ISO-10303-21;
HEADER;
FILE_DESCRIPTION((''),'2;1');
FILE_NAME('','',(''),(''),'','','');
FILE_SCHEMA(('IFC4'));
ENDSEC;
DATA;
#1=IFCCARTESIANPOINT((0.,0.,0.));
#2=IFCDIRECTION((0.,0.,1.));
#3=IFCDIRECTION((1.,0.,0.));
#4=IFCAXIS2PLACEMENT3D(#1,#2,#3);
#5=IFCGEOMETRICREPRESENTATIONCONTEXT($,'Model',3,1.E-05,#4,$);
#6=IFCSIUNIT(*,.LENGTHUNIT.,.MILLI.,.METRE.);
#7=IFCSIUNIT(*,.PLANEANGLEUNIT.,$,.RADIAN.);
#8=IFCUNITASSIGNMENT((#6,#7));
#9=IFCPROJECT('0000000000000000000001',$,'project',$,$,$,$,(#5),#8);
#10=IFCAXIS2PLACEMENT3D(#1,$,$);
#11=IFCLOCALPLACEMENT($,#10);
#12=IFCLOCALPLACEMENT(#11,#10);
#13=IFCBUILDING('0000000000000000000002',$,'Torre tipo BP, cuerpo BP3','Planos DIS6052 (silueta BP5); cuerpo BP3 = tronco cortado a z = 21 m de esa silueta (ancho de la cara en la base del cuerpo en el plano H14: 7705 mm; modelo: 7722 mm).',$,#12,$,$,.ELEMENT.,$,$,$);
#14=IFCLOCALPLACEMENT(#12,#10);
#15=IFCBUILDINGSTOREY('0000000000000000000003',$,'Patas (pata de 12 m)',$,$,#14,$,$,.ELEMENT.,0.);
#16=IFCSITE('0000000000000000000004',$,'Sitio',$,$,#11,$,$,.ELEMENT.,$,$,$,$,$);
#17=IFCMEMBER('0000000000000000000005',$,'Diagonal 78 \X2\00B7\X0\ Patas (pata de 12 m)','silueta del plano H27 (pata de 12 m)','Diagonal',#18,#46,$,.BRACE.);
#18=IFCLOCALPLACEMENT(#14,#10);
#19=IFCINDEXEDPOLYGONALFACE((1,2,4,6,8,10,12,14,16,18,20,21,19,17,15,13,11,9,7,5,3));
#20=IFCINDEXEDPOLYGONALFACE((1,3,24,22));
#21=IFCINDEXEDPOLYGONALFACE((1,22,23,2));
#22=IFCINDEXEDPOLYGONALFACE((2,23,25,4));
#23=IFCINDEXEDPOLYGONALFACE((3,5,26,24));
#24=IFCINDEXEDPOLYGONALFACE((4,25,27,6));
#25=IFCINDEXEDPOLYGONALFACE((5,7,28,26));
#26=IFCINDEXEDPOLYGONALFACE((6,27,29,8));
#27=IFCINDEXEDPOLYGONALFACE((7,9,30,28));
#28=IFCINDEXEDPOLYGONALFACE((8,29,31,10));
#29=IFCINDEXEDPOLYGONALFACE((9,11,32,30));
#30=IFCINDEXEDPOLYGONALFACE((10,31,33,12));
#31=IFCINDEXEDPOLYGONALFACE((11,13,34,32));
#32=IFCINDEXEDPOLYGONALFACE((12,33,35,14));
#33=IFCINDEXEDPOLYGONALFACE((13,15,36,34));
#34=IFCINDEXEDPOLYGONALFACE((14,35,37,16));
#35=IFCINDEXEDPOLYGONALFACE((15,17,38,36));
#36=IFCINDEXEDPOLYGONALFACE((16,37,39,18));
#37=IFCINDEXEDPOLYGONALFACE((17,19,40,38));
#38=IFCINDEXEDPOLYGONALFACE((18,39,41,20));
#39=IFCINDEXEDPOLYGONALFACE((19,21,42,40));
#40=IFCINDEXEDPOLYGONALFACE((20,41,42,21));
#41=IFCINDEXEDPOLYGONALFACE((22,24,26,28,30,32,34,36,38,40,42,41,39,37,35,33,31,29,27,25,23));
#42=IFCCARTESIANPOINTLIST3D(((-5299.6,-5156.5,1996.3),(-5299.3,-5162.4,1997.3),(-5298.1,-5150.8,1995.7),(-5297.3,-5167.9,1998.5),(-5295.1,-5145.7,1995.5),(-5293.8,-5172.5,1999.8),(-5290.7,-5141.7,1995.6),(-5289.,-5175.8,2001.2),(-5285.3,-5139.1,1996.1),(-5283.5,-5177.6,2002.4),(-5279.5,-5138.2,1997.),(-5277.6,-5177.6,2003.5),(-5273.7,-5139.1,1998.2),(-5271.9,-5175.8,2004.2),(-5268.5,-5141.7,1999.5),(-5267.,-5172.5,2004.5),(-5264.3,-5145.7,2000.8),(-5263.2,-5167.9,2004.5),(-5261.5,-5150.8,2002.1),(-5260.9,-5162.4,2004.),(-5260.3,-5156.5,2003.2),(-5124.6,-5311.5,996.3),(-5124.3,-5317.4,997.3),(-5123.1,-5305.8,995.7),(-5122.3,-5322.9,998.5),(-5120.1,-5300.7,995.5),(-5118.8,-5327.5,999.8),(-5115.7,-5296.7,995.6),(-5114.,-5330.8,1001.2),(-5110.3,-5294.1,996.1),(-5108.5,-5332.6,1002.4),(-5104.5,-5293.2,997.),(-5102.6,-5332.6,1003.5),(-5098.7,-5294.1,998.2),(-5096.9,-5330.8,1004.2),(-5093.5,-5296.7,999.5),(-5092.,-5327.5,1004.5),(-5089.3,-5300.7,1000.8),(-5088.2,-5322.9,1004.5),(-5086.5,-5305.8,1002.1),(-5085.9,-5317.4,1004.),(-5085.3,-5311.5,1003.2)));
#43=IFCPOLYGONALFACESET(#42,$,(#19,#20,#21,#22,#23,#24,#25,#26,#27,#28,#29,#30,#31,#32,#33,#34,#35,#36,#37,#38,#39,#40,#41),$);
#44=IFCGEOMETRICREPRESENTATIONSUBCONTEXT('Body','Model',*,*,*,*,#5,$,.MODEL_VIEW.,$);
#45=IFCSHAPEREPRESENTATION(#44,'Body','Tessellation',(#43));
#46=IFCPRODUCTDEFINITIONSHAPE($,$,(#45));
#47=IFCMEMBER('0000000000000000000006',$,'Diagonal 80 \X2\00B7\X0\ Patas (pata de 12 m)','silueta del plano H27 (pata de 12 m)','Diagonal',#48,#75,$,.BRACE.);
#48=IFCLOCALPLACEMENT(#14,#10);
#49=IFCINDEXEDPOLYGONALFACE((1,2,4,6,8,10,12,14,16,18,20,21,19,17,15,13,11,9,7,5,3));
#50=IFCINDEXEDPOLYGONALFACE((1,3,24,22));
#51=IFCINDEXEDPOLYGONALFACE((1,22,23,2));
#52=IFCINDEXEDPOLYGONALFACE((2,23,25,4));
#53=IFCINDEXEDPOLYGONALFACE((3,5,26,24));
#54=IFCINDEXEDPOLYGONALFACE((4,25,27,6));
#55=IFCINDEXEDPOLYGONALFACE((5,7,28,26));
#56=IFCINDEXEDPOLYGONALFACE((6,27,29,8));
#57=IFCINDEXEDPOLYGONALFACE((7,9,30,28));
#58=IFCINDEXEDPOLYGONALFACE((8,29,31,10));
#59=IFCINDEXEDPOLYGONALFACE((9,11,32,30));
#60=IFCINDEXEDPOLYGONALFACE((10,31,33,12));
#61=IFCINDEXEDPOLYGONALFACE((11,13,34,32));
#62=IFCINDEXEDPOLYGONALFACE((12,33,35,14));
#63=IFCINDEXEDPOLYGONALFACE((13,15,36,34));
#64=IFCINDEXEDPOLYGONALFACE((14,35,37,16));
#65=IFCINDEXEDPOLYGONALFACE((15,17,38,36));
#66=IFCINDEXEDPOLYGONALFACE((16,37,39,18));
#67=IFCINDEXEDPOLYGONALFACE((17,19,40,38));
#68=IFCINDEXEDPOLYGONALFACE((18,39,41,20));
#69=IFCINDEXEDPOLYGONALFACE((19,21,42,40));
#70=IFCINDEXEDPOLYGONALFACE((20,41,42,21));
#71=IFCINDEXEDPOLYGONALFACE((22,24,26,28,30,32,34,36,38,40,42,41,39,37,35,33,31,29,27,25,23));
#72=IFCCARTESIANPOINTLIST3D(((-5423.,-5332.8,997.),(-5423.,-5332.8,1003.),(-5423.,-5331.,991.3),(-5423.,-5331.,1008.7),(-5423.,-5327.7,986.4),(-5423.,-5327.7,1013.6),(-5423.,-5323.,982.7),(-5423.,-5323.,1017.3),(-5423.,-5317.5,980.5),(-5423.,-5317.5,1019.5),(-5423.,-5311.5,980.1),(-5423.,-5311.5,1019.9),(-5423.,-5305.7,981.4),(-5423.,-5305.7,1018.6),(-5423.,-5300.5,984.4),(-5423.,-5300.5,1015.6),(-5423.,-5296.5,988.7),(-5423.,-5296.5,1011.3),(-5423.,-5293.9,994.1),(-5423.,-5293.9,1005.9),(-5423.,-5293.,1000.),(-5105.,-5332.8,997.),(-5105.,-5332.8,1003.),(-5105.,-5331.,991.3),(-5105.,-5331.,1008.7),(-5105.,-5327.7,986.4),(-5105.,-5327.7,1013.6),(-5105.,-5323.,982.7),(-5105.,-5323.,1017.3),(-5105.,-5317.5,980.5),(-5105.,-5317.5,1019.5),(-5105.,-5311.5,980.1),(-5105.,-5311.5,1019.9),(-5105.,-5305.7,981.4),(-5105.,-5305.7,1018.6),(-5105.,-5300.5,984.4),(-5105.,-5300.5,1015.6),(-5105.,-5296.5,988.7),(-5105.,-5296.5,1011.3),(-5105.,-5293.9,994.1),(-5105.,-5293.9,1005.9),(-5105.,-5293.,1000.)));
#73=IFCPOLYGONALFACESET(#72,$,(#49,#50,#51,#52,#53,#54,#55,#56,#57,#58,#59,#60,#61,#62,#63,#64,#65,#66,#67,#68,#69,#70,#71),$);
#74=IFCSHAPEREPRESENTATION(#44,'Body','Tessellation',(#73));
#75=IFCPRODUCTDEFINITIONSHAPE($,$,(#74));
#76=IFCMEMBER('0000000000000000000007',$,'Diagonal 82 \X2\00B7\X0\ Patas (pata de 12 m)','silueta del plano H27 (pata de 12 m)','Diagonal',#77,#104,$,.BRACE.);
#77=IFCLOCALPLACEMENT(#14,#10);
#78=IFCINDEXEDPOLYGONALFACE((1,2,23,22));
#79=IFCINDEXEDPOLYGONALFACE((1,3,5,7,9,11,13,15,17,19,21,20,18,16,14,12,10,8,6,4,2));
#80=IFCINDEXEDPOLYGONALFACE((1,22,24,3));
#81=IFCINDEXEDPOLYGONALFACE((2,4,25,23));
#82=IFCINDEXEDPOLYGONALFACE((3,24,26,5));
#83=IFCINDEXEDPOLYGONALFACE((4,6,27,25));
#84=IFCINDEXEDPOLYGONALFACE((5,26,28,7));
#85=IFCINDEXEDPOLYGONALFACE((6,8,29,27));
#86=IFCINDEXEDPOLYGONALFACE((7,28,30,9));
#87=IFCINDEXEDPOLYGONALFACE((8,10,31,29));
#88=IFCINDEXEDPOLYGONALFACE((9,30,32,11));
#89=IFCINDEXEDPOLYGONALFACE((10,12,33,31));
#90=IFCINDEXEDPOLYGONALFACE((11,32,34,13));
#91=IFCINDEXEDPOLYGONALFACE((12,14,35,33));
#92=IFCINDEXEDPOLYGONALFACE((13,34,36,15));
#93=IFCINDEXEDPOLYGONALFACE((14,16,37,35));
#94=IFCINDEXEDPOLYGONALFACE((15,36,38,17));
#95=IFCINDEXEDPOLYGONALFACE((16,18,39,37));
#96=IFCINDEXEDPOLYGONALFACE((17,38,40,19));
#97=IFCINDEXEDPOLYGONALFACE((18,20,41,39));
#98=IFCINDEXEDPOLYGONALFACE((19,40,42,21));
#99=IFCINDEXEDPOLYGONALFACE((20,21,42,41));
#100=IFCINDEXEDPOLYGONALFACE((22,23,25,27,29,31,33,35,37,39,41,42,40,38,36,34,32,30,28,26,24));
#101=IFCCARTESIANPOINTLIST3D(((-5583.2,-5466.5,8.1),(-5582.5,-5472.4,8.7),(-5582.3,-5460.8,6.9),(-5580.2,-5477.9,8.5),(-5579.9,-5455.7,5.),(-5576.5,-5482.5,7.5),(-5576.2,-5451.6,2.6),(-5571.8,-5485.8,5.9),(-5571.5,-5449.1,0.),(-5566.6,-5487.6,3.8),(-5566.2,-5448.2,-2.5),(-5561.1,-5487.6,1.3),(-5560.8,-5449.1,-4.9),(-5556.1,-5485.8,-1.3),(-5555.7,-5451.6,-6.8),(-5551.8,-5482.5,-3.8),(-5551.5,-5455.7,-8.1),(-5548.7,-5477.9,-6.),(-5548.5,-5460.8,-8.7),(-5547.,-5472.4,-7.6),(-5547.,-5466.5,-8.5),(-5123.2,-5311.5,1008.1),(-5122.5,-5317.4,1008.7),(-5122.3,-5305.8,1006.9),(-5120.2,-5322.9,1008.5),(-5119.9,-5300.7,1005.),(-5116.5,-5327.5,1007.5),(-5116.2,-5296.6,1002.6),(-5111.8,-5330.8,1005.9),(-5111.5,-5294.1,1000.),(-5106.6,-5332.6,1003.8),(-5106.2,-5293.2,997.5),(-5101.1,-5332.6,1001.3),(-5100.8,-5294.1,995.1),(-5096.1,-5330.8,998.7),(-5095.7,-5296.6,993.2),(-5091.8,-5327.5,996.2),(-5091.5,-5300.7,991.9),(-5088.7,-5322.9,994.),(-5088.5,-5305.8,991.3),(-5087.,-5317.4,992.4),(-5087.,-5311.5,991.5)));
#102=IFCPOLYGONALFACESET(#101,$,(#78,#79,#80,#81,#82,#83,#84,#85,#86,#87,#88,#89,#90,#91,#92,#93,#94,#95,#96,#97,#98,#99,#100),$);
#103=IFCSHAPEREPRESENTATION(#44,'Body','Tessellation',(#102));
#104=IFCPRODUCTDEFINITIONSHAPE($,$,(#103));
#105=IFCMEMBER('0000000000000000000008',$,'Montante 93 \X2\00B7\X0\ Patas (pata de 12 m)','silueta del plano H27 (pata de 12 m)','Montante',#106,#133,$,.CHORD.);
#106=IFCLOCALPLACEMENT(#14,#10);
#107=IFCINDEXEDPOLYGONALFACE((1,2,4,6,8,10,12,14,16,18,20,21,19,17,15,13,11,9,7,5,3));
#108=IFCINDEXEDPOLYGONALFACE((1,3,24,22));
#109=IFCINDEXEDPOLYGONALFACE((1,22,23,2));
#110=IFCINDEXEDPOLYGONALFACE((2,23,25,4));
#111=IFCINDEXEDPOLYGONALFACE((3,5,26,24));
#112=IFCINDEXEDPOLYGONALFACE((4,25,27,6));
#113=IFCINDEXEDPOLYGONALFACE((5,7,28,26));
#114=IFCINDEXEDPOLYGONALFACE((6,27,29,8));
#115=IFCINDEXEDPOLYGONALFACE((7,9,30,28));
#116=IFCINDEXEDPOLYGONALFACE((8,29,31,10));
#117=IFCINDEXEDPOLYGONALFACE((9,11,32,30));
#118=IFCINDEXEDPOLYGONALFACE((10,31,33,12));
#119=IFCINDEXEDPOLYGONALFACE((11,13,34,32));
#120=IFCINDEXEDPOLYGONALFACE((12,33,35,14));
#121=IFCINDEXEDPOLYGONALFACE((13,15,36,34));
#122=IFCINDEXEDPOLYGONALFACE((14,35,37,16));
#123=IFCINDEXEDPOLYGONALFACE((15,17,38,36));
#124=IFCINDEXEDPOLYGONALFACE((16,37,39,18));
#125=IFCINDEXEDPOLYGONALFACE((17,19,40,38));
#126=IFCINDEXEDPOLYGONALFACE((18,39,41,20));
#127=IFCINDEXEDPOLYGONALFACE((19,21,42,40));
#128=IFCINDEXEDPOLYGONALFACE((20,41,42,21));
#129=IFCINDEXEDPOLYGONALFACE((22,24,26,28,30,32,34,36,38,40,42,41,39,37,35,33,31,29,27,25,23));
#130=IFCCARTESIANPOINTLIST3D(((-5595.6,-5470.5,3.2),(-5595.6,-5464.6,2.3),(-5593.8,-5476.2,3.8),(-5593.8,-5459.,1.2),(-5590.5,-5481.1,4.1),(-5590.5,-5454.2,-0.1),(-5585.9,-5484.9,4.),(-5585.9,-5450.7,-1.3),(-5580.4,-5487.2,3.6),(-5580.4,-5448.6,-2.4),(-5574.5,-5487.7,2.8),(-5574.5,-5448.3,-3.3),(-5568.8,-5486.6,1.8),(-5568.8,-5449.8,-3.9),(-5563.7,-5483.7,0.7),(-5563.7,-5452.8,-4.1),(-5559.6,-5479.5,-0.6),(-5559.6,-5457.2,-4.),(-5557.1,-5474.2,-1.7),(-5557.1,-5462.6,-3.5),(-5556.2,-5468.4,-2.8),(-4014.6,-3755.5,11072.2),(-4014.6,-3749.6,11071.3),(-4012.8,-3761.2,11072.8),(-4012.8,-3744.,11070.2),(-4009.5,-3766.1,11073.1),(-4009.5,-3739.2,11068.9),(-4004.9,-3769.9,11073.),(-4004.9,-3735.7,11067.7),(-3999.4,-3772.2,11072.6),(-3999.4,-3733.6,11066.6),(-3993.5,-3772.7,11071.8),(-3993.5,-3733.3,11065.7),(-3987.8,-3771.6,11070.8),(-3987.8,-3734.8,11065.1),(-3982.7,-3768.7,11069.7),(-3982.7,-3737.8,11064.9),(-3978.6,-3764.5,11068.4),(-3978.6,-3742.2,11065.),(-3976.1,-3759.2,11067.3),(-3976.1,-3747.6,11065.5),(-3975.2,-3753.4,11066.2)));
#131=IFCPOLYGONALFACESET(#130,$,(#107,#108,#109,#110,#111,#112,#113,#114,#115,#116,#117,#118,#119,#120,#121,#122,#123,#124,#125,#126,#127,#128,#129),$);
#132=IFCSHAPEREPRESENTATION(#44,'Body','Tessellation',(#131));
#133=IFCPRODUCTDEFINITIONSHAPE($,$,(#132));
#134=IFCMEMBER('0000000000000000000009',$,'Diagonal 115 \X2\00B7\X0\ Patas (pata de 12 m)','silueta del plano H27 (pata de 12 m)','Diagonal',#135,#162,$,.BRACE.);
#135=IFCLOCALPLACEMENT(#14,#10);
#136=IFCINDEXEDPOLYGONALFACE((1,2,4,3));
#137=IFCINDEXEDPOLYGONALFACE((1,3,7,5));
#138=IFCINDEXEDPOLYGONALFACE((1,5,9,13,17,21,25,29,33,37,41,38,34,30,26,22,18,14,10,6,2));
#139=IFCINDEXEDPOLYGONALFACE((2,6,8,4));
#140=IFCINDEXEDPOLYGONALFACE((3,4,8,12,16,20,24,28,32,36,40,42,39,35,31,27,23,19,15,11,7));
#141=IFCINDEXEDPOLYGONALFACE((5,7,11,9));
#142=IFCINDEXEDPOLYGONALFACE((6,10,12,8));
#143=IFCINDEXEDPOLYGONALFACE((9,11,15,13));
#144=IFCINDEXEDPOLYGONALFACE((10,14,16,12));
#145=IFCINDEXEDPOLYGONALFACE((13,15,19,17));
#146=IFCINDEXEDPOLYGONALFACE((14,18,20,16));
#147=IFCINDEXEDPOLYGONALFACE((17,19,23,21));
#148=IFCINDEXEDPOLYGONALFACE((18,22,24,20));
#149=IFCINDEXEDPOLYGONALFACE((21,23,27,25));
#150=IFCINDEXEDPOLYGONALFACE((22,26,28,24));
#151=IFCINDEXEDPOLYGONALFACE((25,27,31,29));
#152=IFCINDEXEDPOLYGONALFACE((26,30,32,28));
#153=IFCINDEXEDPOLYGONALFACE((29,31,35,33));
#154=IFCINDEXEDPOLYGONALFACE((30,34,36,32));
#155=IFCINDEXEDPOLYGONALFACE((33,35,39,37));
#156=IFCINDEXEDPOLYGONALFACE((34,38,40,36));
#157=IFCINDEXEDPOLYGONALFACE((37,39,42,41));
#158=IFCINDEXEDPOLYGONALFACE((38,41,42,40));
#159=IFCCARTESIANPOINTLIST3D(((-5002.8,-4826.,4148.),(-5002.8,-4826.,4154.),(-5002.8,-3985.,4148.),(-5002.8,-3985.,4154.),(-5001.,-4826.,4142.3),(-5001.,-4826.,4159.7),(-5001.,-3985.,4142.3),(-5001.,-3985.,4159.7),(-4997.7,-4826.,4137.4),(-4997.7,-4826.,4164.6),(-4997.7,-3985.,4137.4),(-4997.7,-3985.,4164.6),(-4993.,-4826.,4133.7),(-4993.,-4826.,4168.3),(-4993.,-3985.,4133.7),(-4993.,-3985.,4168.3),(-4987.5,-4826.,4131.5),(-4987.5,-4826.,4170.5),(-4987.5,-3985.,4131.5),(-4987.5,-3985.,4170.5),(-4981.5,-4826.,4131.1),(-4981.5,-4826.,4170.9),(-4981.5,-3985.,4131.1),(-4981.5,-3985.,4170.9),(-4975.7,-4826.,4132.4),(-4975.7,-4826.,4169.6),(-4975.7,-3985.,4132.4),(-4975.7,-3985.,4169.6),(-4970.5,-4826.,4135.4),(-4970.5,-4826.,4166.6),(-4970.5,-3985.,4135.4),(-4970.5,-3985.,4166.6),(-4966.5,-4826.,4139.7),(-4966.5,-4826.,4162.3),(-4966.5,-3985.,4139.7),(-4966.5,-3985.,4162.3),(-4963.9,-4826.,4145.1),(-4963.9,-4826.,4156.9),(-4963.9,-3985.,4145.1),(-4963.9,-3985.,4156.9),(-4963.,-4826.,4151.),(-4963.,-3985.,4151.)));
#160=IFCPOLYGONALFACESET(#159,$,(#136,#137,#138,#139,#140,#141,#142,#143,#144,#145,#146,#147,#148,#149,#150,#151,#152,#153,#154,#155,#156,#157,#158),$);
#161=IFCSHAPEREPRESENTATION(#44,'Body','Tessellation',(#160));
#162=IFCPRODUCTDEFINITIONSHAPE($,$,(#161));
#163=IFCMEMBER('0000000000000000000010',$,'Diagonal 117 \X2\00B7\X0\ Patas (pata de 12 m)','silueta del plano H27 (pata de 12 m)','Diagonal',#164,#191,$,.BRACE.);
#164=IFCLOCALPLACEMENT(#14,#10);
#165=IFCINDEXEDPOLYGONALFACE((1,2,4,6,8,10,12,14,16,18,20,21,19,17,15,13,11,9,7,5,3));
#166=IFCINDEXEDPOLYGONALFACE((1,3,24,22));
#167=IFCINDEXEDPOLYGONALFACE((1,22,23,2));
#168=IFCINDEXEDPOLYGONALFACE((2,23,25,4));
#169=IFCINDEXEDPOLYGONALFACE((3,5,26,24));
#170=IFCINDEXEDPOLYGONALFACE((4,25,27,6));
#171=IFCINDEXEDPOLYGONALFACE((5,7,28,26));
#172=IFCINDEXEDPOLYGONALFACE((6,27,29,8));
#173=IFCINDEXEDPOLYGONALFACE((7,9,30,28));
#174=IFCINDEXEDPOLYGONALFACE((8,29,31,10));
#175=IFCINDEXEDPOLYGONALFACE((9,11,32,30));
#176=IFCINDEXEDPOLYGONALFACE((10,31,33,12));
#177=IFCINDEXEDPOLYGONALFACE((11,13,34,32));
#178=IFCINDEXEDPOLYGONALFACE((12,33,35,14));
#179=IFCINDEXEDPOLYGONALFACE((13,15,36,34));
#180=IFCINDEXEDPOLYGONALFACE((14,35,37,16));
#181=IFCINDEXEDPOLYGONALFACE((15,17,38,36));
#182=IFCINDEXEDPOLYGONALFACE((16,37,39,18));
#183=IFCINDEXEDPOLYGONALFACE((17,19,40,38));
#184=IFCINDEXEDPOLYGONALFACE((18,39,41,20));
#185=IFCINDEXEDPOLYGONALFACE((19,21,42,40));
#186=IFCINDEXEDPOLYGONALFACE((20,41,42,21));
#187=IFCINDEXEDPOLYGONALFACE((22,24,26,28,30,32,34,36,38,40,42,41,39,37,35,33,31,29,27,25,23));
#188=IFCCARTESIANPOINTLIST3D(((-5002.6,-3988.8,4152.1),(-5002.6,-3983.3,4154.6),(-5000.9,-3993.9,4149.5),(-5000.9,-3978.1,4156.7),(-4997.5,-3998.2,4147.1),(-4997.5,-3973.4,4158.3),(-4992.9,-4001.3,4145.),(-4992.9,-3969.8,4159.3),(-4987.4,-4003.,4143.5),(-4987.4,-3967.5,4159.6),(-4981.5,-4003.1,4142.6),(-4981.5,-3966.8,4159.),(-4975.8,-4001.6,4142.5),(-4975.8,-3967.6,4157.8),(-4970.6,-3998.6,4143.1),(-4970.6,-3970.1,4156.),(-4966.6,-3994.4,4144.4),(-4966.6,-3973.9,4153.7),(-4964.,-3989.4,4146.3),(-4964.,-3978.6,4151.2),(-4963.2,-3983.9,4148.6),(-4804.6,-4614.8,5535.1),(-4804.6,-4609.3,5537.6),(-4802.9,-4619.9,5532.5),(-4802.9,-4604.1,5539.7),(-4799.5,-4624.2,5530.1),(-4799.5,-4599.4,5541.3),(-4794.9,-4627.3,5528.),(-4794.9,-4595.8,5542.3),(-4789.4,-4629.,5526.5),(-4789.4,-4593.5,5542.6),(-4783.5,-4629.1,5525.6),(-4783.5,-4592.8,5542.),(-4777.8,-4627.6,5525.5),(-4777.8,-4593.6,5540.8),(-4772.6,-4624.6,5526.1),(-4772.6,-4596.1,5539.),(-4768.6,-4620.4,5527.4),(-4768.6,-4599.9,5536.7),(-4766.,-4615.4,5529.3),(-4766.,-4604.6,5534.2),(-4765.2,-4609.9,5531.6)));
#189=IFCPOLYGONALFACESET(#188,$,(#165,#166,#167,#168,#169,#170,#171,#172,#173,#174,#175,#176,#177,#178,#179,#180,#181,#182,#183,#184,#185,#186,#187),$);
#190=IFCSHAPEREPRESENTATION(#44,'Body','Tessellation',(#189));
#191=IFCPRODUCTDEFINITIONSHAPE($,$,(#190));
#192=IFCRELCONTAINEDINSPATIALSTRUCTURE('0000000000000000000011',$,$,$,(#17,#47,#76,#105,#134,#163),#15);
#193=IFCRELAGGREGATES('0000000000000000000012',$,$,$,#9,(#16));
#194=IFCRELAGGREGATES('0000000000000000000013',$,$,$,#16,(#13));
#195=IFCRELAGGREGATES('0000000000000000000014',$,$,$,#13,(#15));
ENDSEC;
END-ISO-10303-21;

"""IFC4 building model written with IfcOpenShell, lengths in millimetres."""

from ifc_helpers import new_model, si_unit, frame, origin, origin_with_axes, place, context, subcontext, project, spatial, circle, extrude, element, save


model = new_model("IFC4")

# Units and contexts
model_context = context("Model", 3, precision=1e-05, world=origin_with_axes())
body_context = subcontext(model_context, "Body", "Model", "MODEL_VIEW")
ifc_project = project(units=[si_unit("LENGTHUNIT", "METRE", prefix="MILLI"), si_unit("PLANEANGLEUNIT", "RADIAN")], contexts=[model_context])

# Site, building, storey
site_placement = place(None, origin())
site = spatial("IfcSite", under=ifc_project, at=site_placement, Name="Sitio", CompositionType="ELEMENT")
building_placement = place(site_placement, origin())
building = spatial("IfcBuilding", under=site, at=building_placement, Name="Torre tipo BP, cuerpo BP3", Description="Planos DIS6052 (silueta BP5); cuerpo BP3 = tronco cortado a z = 21 m de esa silueta (ancho de la cara en la base del cuerpo en el plano H14: 7705 mm; modelo: 7722 mm).", CompositionType="ELEMENT")
storey_placement = place(building_placement, origin())
storey = spatial("IfcBuildingStorey", under=building, at=storey_placement, Name="Patas (pata de 12 m)", CompositionType="ELEMENT", Elevation=0.0)

# Members
member_1_placement = place(storey_placement, frame((-5105.0, -5313.0, 1000.0), z_axis=(-0.170406, 0.150931, 0.973746), x_axis=(0.026017, 0.988544, -0.148671)))
element("IfcMember", 1, at=member_1_placement, inside=storey, Name="Diagonal 78 · Patas (pata de 12 m)", Description="silueta del plano H27 (pata de 12 m)", ObjectType="Diagonal", PredefinedType="BRACE", context=body_context, shape_type="SweptSolid", body=[
    extrude(circle(Radius=20.0), None, (0.0, 0.0, 1.0), 1027.0),
])
member_2_placement = place(storey_placement, frame((-5423.0, -5313.0, 1000.0), z_axis=(1.0, 0.0, 0.0), x_axis=(0.0, 1.0, 0.0)))
element("IfcMember", 2, at=member_2_placement, inside=storey, Name="Diagonal 80 · Patas (pata de 12 m)", Description="silueta del plano H27 (pata de 12 m)", ObjectType="Diagonal", PredefinedType="BRACE", context=body_context, shape_type="SweptSolid", body=[
    extrude(circle(Radius=20.0), None, (0.0, 0.0, 1.0), 318.0),
])
member_3_placement = place(storey_placement, frame((-5565.0, -5468.0, 0.0), z_axis=(0.413823, 0.13944, 0.899615), x_axis=(-0.058273, 0.99023, -0.12668)))
element("IfcMember", 3, at=member_3_placement, inside=storey, Name="Diagonal 82 · Patas (pata de 12 m)", Description="silueta del plano H27 (pata de 12 m)", ObjectType="Diagonal", PredefinedType="BRACE", context=body_context, shape_type="SweptSolid", body=[
    extrude(circle(Radius=20.0), None, (0.0, 0.0, 1.0), 1111.6),
])
member_4_placement = place(storey_placement, frame((-5576.0, -5468.0, 0.0), z_axis=(0.139762, 0.151608, 0.97851), x_axis=(0.990185, -0.021399, -0.138114)))
element("IfcMember", 4, at=member_4_placement, inside=storey, Name="Montante 93 · Patas (pata de 12 m)", Description="silueta del plano H27 (pata de 12 m)", ObjectType="Montante", PredefinedType="CHORD", context=body_context, shape_type="SweptSolid", body=[
    extrude(circle(Radius=20.0), None, (0.0, 0.0, 1.0), 11312.1),
])
member_5_placement = place(storey_placement, frame((-4983.0, -4826.0, 4151.0), z_axis=(0.0, 1.0, 0.0), x_axis=(1.0, 0.0, 0.0)))
element("IfcMember", 5, at=member_5_placement, inside=storey, Name="Diagonal 115 · Patas (pata de 12 m)", Description="silueta del plano H27 (pata de 12 m)", ObjectType="Diagonal", PredefinedType="BRACE", context=body_context, shape_type="SweptSolid", body=[
    extrude(circle(Radius=20.0), None, (0.0, 0.0, 1.0), 841.0),
])
member_6_placement = place(storey_placement, frame((-4983.0, -3985.0, 4151.0), z_axis=(0.129333, -0.4089, 0.903368), x_axis=(0.991601, 0.053332, -0.117824)))
element("IfcMember", 6, at=member_6_placement, inside=storey, Name="Diagonal 117 · Patas (pata de 12 m)", Description="silueta del plano H27 (pata de 12 m)", ObjectType="Diagonal", PredefinedType="BRACE", context=body_context, shape_type="SweptSolid", body=[
    extrude(circle(Radius=20.0), None, (0.0, 0.0, 1.0), 1530.9),
])

save(model, "model.ifc")
